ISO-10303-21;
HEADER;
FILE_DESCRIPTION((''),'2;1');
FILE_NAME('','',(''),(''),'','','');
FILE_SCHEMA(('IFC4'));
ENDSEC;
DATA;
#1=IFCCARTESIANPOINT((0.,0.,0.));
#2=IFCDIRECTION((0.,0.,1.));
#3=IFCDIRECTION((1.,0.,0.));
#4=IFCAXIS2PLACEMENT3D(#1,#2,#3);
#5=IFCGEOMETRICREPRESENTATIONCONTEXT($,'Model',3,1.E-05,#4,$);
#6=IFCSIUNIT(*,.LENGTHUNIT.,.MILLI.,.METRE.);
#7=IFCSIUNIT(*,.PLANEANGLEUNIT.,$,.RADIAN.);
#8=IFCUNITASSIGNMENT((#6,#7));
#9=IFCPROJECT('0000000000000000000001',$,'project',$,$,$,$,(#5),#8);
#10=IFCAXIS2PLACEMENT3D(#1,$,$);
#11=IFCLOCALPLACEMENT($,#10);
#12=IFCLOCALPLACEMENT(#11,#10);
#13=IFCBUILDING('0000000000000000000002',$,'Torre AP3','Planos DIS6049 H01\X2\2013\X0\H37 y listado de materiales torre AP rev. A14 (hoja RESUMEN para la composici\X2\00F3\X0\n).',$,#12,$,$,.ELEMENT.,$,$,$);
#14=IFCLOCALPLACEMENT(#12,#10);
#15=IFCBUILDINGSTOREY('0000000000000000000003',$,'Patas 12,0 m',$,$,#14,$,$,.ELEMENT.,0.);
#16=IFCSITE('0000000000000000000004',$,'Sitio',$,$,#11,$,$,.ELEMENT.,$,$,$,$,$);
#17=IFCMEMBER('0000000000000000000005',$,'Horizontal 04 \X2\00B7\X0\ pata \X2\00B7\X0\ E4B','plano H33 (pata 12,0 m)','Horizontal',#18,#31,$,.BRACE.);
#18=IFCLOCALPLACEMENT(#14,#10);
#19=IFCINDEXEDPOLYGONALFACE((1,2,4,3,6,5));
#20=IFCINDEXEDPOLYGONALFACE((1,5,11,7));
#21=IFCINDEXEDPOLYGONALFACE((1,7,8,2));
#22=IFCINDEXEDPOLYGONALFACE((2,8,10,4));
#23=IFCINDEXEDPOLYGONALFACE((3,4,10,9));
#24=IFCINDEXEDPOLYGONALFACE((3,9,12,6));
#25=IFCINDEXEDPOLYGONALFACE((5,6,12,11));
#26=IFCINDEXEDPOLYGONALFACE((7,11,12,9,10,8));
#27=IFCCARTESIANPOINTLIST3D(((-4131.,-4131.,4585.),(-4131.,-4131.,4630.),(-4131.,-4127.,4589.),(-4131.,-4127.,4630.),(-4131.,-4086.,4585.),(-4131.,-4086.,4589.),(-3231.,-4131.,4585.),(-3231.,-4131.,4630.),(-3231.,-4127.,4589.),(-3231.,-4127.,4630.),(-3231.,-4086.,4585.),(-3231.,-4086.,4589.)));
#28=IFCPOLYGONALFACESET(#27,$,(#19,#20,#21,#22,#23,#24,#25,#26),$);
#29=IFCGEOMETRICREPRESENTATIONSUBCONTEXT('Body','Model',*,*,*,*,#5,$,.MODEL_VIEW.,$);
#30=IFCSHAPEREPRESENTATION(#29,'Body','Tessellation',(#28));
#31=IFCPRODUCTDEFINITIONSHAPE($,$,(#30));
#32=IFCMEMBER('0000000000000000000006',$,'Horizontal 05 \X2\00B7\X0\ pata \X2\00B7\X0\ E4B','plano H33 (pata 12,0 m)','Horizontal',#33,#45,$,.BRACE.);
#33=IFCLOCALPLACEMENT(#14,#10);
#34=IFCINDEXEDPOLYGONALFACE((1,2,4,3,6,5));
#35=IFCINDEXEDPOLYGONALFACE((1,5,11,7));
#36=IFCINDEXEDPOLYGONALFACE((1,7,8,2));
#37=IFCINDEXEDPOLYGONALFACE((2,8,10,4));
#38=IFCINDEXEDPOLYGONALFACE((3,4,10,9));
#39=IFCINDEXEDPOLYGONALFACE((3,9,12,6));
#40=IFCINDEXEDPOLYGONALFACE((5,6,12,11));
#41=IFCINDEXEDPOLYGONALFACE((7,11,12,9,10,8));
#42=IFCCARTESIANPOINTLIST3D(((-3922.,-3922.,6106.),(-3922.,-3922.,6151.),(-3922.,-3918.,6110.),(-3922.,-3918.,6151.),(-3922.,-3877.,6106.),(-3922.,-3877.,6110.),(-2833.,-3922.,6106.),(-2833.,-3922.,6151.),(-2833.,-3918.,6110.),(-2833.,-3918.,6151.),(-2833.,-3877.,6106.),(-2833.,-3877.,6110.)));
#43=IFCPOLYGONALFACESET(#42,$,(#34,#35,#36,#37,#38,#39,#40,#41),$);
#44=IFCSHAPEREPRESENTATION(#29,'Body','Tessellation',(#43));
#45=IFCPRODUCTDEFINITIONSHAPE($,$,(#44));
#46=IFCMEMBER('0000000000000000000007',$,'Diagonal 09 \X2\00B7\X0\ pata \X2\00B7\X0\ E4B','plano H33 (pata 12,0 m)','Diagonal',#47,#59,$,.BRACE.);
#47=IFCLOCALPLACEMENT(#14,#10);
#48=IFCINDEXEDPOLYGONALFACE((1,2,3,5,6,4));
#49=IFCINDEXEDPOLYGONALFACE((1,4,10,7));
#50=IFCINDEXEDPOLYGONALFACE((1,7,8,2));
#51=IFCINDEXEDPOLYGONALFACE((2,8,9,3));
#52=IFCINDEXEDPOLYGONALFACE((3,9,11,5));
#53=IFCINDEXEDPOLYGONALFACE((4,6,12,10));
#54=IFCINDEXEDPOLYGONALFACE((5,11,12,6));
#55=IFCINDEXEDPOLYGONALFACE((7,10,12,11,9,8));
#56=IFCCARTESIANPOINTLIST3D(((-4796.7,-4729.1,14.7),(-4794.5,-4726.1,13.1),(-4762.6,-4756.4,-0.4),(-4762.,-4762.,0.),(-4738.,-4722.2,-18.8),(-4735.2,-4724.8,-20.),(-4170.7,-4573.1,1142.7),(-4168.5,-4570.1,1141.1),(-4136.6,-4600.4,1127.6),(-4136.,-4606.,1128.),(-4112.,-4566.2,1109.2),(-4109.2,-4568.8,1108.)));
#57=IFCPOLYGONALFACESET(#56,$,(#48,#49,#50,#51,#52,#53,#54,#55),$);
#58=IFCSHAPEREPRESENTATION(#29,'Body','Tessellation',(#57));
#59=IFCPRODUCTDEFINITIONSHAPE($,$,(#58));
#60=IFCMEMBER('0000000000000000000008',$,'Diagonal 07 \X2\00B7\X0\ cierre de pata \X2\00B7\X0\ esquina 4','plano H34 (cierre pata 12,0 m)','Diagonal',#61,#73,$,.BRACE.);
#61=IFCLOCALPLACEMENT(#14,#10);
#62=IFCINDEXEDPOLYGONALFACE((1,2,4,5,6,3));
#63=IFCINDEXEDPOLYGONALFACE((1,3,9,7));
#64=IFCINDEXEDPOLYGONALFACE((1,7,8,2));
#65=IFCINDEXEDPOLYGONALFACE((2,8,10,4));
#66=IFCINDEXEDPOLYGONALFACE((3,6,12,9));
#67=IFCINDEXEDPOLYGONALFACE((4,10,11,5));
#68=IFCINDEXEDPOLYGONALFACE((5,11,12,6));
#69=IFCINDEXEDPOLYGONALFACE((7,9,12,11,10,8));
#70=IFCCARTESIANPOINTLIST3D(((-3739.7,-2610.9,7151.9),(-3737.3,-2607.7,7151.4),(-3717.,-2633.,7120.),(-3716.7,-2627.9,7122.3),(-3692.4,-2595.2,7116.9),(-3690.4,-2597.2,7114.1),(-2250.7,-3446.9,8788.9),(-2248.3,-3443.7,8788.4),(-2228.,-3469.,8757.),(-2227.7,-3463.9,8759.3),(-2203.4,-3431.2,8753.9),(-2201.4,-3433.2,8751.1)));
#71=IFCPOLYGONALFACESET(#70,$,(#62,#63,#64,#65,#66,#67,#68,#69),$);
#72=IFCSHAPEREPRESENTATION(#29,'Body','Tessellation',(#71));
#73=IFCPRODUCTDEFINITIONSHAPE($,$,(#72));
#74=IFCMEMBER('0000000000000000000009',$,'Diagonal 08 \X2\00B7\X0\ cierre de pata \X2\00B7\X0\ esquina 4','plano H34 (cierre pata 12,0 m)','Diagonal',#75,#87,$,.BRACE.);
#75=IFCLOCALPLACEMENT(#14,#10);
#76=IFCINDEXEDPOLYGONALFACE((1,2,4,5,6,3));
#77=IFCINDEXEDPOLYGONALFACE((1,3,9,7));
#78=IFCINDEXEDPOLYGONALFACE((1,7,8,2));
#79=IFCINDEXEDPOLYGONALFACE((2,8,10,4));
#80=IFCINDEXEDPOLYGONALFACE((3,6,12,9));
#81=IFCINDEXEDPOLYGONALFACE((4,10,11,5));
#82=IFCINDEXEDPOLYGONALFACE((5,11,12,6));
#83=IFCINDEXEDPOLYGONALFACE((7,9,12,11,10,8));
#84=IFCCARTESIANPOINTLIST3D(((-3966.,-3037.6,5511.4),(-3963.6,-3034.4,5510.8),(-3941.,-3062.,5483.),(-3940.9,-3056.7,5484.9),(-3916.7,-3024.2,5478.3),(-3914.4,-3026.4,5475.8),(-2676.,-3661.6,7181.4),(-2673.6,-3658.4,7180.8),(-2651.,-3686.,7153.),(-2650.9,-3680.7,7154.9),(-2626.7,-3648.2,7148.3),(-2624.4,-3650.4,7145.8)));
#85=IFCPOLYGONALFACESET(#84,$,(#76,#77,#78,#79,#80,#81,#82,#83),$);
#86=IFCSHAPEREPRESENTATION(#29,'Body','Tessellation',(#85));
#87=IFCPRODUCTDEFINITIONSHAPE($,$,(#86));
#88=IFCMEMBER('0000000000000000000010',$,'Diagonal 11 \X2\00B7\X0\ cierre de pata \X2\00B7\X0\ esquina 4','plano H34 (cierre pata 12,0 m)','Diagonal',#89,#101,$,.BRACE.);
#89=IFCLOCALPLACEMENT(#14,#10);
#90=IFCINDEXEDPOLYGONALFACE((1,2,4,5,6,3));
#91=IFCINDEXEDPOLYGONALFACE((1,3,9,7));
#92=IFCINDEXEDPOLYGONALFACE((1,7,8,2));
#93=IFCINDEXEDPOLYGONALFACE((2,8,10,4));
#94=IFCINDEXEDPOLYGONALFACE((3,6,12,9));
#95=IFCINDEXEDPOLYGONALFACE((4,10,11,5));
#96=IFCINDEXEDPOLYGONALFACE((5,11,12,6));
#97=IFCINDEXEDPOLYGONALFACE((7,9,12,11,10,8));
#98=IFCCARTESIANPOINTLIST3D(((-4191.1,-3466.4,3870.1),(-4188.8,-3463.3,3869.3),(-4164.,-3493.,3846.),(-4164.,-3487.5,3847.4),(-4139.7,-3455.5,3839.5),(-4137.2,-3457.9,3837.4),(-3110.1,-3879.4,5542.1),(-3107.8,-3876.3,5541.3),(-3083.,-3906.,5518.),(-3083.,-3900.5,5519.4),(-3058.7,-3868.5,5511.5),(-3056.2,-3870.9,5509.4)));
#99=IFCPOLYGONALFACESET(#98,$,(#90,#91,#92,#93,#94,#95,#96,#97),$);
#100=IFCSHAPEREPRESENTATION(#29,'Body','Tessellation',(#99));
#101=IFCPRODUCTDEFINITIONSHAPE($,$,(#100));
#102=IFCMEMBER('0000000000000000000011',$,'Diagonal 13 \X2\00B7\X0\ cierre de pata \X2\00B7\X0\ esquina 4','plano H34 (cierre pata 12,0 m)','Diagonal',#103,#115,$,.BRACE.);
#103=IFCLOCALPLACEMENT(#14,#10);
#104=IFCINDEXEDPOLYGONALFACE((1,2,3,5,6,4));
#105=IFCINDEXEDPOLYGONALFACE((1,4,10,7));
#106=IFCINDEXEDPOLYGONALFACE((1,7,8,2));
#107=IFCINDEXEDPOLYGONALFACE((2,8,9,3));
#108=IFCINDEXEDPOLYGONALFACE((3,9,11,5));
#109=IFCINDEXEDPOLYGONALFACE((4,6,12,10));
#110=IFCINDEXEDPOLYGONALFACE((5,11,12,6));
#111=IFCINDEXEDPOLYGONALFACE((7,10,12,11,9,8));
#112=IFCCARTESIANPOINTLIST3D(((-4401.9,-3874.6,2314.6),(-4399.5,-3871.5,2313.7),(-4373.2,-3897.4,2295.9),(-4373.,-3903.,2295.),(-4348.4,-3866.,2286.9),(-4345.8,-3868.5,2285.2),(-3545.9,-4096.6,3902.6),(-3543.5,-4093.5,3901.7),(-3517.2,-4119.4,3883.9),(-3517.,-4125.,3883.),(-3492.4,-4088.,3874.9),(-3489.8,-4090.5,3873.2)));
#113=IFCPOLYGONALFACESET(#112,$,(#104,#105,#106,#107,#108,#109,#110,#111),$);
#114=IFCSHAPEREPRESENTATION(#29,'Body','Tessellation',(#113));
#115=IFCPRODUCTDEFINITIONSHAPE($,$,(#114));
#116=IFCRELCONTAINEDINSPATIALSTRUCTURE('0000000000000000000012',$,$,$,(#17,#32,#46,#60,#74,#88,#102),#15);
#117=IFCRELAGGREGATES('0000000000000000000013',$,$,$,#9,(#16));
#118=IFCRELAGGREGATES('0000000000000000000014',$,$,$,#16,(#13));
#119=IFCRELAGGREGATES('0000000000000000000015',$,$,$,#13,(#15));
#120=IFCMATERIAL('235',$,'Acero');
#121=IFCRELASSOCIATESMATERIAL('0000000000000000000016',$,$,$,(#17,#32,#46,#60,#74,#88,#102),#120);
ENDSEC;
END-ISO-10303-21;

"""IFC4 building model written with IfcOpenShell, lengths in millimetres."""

from ifc_helpers import new_model, si_unit, frame, frame_2d, origin, origin_with_axes, place, context, subcontext, project, spatial, l_section, extrude, material, element, save


model = new_model("IFC4")

# Units and contexts
model_context = context("Model", 3, precision=1e-05, world=origin_with_axes())
body_context = subcontext(model_context, "Body", "Model", "MODEL_VIEW")
ifc_project = project(units=[si_unit("LENGTHUNIT", "METRE", prefix="MILLI"), si_unit("PLANEANGLEUNIT", "RADIAN")], contexts=[model_context])

# Site, building, storey
site_placement = place(None, origin())
site = spatial("IfcSite", under=ifc_project, at=site_placement, Name="Sitio", CompositionType="ELEMENT")
building_placement = place(site_placement, origin())
building = spatial("IfcBuilding", under=site, at=building_placement, Name="Torre AP3", Description="Planos DIS6049 H01–H37 y listado de materiales torre AP rev. A14 (hoja RESUMEN para la composición).", CompositionType="ELEMENT")
storey_placement = place(building_placement, origin())
storey = spatial("IfcBuildingStorey", under=building, at=storey_placement, Name="Patas 12,0 m", CompositionType="ELEMENT", Elevation=0.0)

# Members
ifc_material_1 = material(Name="235", Category="Acero")
member_1_placement = place(storey_placement, frame((-4131.0, -4131.0, 4585.0), z_axis=(1.0, 0.0, 0.0), x_axis=(0.0, 1.0, 0.0)))
element("IfcMember", 1, at=member_1_placement, inside=storey, material=ifc_material_1, Name="Horizontal 04 · pata · E4B", Description="plano H33 (pata 12,0 m)", ObjectType="Horizontal", PredefinedType="BRACE", context=body_context, shape_type="SweptSolid", body=[
    extrude(l_section(Depth=45.0, Width=45.0, Thickness=4.0, at=frame_2d((22.5, 22.5))), None, (0.0, 0.0, 1.0), 900.0),
])
member_2_placement = place(storey_placement, frame((-3922.0, -3922.0, 6106.0), z_axis=(1.0, 0.0, 0.0), x_axis=(0.0, 1.0, 0.0)))
element("IfcMember", 2, at=member_2_placement, inside=storey, material=ifc_material_1, Name="Horizontal 05 · pata · E4B", Description="plano H33 (pata 12,0 m)", ObjectType="Horizontal", PredefinedType="BRACE", context=body_context, shape_type="SweptSolid", body=[
    extrude(l_section(Depth=45.0, Width=45.0, Thickness=4.0, at=frame_2d((22.5, 22.5))), None, (0.0, 0.0, 1.0), 1089.0),
])
member_3_placement = place(storey_placement, frame((-4762.0, -4762.0, 0.0), z_axis=(0.481739, 0.12005, 0.868053), x_axis=(0.53622, 0.743093, -0.400351)))
element("IfcMember", 3, at=member_3_placement, inside=storey, material=ifc_material_1, Name="Diagonal 09 · pata · E4B", Description="plano H33 (pata 12,0 m)", ObjectType="Diagonal", PredefinedType="BRACE", context=body_context, shape_type="SweptSolid", body=[
    extrude(l_section(Depth=50.0, Width=50.0, Thickness=4.0, at=frame_2d((25.0, 25.0))), None, (0.0, 0.0, 1.0), 1299.5),
])
member_4_placement = place(storey_placement, frame((-3717.0, -2633.0, 7120.0), z_axis=(0.629454, -0.353407, 0.692019), x_axis=(0.591004, 0.795946, -0.13109)))
element("IfcMember", 4, at=member_4_placement, inside=storey, material=ifc_material_1, Name="Diagonal 07 · cierre de pata · esquina 4", Description="plano H34 (cierre pata 12,0 m)", ObjectType="Diagonal", PredefinedType="BRACE", context=body_context, shape_type="SweptSolid", body=[
    extrude(l_section(Depth=45.0, Width=45.0, Thickness=4.0, at=frame_2d((22.5, 22.5))), None, (0.0, 0.0, 1.0), 2365.5),
])
member_5_placement = place(storey_placement, frame((-3941.0, -3062.0, 5483.0), z_axis=(0.58622, -0.283567, 0.758905), x_axis=(0.59032, 0.79107, -0.16041)))
element("IfcMember", 5, at=member_5_placement, inside=storey, material=ifc_material_1, Name="Diagonal 08 · cierre de pata · esquina 4", Description="plano H34 (cierre pata 12,0 m)", ObjectType="Diagonal", PredefinedType="BRACE", context=body_context, shape_type="SweptSolid", body=[
    extrude(l_section(Depth=45.0, Width=45.0, Thickness=4.0, at=frame_2d((22.5, 22.5))), None, (0.0, 0.0, 1.0), 2200.5),
])
member_6_placement = place(storey_placement, frame((-4164.0, -3493.0, 3846.0), z_axis=(0.531622, -0.203108, 0.822268), x_axis=(0.594618, 0.780855, -0.191561)))
element("IfcMember", 6, at=member_6_placement, inside=storey, material=ifc_material_1, Name="Diagonal 11 · cierre de pata · esquina 4", Description="plano H34 (cierre pata 12,0 m)", ObjectType="Diagonal", PredefinedType="BRACE", context=body_context, shape_type="SweptSolid", body=[
    extrude(l_section(Depth=45.0, Width=45.0, Thickness=4.0, at=frame_2d((22.5, 22.5))), None, (0.0, 0.0, 1.0), 2033.4),
])
member_7_placement = place(storey_placement, frame((-4373.0, -3903.0, 2295.0), z_axis=(0.470944, -0.122137, 0.873667), x_axis=(0.604634, 0.765844, -0.21886)))
element("IfcMember", 7, at=member_7_placement, inside=storey, material=ifc_material_1, Name="Diagonal 13 · cierre de pata · esquina 4", Description="plano H34 (cierre pata 12,0 m)", ObjectType="Diagonal", PredefinedType="BRACE", context=body_context, shape_type="SweptSolid", body=[
    extrude(l_section(Depth=45.0, Width=45.0, Thickness=4.0, at=frame_2d((22.5, 22.5))), None, (0.0, 0.0, 1.0), 1817.6),
])

save(model, "model.ifc")
